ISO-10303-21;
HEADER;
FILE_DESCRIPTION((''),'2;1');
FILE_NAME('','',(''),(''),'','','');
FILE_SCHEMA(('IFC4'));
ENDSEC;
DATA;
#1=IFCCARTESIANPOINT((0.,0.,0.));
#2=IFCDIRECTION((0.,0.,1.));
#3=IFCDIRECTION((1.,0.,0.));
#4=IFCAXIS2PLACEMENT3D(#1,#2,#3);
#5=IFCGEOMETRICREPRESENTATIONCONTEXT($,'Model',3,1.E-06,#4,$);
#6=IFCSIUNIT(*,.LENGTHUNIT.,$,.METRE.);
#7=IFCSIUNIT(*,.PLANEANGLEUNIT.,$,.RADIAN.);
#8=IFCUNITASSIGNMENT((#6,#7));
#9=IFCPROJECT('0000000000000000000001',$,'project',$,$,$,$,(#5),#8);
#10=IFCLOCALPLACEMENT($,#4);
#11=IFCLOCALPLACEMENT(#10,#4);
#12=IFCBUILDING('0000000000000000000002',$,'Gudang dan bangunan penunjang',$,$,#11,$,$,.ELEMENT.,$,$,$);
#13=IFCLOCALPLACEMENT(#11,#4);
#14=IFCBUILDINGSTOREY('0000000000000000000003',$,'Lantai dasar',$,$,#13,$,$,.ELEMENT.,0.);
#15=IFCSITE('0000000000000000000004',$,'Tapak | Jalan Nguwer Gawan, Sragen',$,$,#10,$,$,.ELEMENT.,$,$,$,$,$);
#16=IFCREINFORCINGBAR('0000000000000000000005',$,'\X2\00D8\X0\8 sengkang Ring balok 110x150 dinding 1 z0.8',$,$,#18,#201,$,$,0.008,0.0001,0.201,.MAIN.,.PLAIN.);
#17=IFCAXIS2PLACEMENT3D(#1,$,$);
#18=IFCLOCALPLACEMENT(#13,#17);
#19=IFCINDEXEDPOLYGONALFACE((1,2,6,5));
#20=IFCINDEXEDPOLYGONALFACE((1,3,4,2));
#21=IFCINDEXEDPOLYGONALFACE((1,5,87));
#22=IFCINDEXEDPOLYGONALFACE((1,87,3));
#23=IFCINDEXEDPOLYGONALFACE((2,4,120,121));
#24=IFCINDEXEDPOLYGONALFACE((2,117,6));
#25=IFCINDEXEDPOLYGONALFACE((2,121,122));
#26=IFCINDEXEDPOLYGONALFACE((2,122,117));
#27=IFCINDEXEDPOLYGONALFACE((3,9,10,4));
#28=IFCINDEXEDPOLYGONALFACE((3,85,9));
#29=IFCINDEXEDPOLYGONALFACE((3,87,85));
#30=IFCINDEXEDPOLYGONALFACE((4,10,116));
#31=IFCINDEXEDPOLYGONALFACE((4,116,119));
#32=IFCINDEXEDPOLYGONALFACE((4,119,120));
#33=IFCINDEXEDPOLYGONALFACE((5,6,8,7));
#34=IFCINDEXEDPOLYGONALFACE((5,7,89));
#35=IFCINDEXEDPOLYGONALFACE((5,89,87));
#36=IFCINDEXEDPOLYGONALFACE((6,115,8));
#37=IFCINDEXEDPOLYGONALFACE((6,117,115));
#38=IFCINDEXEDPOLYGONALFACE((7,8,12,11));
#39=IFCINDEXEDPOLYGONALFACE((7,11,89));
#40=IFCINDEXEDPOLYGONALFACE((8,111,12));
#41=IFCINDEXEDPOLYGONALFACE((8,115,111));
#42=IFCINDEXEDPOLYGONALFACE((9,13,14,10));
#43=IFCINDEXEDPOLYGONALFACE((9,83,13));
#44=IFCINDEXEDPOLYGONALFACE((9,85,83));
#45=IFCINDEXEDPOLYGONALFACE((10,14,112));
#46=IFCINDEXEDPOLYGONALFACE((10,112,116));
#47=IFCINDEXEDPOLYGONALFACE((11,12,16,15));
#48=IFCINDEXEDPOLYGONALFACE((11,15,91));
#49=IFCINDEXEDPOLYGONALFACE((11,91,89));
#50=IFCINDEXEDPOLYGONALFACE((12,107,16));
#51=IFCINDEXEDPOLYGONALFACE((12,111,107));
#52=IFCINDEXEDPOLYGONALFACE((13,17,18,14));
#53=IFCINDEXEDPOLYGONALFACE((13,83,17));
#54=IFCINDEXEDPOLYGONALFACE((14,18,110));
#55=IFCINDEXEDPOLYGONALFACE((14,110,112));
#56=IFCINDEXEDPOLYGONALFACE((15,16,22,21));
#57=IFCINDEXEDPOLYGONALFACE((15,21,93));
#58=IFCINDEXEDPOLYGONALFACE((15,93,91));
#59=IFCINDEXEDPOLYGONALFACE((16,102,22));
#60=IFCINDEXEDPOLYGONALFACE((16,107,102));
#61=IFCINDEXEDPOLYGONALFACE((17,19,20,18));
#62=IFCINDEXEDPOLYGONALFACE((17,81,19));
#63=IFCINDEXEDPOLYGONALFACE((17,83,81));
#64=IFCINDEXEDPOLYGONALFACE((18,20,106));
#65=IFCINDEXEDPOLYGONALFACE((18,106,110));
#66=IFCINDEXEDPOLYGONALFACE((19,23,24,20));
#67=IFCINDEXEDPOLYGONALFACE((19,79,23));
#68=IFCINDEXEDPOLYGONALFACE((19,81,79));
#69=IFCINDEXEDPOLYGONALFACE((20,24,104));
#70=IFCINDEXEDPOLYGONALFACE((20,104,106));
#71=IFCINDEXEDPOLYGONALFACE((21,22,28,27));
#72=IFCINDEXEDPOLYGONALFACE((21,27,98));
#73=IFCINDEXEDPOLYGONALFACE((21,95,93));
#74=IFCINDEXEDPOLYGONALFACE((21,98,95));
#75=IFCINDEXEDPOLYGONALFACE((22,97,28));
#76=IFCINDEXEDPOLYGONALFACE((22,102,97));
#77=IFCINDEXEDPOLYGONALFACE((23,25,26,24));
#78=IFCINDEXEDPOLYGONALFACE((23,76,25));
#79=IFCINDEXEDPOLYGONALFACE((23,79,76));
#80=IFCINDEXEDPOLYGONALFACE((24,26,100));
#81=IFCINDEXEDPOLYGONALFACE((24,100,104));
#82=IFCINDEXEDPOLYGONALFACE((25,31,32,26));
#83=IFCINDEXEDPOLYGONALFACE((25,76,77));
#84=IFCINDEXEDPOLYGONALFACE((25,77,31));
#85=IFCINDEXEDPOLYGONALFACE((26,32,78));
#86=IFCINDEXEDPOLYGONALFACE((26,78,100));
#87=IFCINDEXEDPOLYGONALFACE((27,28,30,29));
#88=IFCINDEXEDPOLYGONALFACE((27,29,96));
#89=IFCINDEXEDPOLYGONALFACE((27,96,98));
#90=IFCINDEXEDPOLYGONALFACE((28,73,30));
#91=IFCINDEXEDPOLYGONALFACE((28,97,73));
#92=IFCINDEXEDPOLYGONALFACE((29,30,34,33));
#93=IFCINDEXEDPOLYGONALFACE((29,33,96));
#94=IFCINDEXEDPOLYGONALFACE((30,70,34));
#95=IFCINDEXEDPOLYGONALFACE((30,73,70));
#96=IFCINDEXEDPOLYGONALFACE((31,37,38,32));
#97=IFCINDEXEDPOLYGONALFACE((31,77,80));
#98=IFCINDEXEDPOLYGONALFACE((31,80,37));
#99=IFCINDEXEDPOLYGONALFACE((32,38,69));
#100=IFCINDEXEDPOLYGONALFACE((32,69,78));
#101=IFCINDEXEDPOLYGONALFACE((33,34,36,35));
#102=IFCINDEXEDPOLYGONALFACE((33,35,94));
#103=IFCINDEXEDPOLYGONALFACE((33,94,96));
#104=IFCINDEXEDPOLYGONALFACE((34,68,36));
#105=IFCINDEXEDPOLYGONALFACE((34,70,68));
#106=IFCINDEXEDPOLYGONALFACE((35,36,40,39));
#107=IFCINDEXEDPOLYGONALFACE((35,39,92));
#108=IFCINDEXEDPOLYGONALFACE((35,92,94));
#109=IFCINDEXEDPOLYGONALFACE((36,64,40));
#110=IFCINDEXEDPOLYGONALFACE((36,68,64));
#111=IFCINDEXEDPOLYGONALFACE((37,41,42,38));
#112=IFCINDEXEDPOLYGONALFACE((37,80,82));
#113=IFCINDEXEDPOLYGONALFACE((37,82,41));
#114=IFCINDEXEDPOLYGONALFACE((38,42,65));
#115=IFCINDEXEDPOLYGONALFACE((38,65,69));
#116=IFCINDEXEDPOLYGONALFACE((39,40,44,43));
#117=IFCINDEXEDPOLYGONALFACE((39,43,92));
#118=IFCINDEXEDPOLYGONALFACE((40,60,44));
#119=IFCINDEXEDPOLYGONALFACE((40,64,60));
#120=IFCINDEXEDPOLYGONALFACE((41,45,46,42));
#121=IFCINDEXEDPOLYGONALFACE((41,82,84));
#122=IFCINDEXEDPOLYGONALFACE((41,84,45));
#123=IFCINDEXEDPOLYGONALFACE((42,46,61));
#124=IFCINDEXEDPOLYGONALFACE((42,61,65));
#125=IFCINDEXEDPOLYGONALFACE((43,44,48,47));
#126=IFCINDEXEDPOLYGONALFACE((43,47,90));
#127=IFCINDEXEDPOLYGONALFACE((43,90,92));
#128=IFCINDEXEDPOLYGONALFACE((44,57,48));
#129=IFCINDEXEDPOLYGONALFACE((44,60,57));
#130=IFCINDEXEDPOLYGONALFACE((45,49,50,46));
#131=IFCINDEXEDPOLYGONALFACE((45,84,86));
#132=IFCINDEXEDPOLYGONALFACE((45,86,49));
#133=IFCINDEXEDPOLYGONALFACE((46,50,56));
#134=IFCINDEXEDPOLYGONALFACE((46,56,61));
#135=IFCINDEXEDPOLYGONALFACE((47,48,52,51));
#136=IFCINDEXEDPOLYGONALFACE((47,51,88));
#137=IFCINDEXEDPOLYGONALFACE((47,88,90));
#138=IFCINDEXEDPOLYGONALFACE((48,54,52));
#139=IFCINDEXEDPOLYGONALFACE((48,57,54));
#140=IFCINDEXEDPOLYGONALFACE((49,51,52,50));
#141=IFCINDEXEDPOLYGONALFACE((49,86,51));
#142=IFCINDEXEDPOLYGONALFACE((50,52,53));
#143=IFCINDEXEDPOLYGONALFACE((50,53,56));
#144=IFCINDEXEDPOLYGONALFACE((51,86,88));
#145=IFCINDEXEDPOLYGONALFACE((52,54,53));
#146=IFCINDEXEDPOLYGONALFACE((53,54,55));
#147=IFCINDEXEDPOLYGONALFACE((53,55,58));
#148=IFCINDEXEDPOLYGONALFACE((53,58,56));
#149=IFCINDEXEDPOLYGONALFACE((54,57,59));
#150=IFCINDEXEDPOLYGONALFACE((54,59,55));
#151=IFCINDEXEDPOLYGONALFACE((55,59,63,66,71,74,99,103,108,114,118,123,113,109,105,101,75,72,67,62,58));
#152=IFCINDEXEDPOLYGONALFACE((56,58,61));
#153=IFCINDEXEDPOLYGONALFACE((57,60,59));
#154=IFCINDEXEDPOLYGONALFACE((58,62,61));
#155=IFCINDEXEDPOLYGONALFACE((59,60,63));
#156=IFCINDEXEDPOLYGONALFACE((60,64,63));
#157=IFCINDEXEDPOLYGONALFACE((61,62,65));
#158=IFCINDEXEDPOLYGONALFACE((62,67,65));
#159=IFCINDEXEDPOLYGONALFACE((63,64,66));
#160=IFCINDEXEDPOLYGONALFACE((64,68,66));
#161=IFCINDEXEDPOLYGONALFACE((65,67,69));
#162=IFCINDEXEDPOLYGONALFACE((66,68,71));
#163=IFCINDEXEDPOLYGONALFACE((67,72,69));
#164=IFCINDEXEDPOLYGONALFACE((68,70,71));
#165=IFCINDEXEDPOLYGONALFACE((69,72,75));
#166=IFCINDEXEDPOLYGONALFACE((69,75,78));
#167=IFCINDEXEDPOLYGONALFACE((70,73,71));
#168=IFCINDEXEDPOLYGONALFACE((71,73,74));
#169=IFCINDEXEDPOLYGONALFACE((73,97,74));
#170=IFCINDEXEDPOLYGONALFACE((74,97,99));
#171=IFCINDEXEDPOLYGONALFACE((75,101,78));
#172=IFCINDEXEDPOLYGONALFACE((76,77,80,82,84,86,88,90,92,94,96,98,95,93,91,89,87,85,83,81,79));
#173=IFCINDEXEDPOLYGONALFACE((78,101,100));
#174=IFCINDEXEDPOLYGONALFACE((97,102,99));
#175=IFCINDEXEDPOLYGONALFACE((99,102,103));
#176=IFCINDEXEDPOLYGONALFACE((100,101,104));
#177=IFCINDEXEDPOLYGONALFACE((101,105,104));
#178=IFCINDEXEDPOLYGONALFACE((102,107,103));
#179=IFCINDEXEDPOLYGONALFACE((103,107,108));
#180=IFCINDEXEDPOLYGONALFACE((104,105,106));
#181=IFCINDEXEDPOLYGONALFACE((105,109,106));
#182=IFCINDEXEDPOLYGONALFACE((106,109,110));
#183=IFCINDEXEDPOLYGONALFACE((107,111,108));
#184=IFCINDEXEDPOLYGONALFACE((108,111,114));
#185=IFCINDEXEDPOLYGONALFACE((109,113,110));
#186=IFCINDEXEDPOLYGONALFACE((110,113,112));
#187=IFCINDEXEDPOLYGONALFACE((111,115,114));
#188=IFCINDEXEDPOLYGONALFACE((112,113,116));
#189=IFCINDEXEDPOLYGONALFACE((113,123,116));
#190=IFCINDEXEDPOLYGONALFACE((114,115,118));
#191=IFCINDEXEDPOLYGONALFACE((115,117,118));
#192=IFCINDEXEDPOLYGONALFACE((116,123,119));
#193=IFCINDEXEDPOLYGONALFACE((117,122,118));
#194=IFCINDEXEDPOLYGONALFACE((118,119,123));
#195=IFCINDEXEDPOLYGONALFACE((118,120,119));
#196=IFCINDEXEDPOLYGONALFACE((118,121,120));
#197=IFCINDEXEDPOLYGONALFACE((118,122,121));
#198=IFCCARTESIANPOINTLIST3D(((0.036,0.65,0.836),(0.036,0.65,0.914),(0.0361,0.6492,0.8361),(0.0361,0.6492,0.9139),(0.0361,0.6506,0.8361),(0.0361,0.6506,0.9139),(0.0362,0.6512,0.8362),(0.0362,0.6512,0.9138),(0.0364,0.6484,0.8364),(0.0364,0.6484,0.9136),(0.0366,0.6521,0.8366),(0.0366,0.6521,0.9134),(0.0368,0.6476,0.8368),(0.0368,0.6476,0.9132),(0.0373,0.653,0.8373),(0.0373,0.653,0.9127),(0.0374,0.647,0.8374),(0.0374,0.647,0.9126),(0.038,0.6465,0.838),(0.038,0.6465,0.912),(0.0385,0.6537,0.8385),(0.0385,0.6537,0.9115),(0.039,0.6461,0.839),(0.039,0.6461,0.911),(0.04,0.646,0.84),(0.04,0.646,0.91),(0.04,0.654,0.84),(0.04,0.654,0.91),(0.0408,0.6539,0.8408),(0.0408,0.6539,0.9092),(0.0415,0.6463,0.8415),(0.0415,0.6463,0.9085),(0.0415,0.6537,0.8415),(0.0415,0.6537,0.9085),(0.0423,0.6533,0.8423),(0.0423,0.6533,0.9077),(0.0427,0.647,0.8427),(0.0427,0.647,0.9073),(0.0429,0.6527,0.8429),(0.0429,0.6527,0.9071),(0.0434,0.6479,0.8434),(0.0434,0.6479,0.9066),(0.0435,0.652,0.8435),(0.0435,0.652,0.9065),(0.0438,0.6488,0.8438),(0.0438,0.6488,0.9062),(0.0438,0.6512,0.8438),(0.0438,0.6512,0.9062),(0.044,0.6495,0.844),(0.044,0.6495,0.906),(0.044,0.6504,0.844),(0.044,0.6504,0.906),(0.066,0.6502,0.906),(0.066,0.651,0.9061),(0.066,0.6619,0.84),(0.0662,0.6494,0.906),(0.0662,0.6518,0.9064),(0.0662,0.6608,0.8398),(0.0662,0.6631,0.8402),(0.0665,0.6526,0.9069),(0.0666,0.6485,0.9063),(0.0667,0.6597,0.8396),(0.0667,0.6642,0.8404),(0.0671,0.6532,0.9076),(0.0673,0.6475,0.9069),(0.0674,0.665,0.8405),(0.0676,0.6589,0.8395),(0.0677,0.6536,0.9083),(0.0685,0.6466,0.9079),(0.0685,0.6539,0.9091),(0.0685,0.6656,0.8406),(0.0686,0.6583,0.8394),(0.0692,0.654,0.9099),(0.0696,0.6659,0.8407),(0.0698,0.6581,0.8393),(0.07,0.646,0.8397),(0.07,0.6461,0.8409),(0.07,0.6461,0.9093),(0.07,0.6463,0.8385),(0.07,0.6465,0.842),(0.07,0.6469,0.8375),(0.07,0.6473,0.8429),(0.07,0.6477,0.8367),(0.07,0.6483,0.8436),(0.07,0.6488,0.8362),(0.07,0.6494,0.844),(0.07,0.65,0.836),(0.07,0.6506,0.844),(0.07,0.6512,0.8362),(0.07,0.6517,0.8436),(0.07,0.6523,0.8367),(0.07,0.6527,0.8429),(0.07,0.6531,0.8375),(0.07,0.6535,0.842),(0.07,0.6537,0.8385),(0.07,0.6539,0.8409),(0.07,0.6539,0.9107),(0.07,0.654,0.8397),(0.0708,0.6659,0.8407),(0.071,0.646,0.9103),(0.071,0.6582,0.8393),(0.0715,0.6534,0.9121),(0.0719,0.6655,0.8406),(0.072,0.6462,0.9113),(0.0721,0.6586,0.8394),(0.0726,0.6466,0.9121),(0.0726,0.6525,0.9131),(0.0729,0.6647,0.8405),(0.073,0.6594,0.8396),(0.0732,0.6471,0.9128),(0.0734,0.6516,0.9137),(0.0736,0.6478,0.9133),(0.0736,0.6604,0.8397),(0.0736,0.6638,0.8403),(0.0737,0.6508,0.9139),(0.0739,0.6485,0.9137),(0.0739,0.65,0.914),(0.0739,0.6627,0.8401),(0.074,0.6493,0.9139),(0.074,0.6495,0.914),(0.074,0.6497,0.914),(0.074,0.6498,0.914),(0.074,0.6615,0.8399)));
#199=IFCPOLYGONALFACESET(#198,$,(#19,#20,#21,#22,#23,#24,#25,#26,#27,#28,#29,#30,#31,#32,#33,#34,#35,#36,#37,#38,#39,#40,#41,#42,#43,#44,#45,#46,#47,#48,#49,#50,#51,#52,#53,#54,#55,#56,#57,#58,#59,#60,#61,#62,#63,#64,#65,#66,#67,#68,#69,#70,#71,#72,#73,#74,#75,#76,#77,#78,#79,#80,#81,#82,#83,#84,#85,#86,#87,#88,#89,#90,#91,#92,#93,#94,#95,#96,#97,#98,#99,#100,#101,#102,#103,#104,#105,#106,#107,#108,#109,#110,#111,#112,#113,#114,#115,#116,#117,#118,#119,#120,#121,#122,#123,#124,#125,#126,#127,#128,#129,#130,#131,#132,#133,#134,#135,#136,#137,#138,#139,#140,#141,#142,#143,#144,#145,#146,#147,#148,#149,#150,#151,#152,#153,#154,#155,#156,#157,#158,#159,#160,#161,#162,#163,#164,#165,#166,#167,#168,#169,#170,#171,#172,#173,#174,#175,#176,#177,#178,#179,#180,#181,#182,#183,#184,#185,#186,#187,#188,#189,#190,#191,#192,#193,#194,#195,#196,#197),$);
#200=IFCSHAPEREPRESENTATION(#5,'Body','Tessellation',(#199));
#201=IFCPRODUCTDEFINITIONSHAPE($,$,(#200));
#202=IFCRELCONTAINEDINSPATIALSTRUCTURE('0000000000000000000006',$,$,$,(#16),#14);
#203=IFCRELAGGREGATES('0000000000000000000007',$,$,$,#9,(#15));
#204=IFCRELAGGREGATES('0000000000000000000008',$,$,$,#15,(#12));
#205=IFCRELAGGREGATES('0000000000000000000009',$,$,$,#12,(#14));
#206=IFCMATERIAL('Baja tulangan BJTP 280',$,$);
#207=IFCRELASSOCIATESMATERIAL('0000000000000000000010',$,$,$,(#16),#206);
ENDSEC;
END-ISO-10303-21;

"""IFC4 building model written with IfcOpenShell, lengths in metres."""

from ifc_helpers import new_model, entity, si_unit, origin_with_axes, place, context, project, spatial, material, element, save


model = new_model("IFC4")

# Units and contexts
model_context = context("Model", 3, precision=1e-06, world=origin_with_axes())
ifc_project = project(units=[si_unit("LENGTHUNIT", "METRE"), si_unit("PLANEANGLEUNIT", "RADIAN")], contexts=[model_context])

# Site, building, storey
site_placement = place(None, origin_with_axes())
site = spatial("IfcSite", under=ifc_project, at=site_placement, Name="Tapak | Jalan Nguwer Gawan, Sragen", CompositionType="ELEMENT")
building_placement = place(site_placement, origin_with_axes())
building = spatial("IfcBuilding", under=site, at=building_placement, Name="Gudang dan bangunan penunjang", CompositionType="ELEMENT")
storey_placement = place(building_placement, origin_with_axes())
storey = spatial("IfcBuildingStorey", under=building, at=storey_placement, Name="Lantai dasar", CompositionType="ELEMENT", Elevation=0.0)

# Shared definitions
placement = place(None, origin_with_axes())

# Reinforcing bar
ifc_material_1 = material(Name="Baja tulangan BJTP 280")
element("IfcReinforcingBar", 1, at=placement, inside=storey, material=ifc_material_1, Name="Ø8 sengkang Ring balok 110x150 dinding 1 z0.8", BarLength=0.201, BarSurface="PLAIN", CrossSectionArea=0.0001, NominalDiameter=0.008, PredefinedType="MAIN", context=model_context, shape_type="AdvancedSweptSolid", body=[
    entity("IfcSweptDiskSolid", entity("IfcPolyline", [entity("IfcCartesianPoint", [0.07, 0.65, 0.84]), entity("IfcCartesianPoint", [0.04, 0.65, 0.84]), entity("IfcCartesianPoint", [0.04, 0.65, 0.91]), entity("IfcCartesianPoint", [0.07, 0.65, 0.91]), entity("IfcCartesianPoint", [0.07, 0.662, 0.84])]), 0.004),
])

save(model, "model.ifc")
